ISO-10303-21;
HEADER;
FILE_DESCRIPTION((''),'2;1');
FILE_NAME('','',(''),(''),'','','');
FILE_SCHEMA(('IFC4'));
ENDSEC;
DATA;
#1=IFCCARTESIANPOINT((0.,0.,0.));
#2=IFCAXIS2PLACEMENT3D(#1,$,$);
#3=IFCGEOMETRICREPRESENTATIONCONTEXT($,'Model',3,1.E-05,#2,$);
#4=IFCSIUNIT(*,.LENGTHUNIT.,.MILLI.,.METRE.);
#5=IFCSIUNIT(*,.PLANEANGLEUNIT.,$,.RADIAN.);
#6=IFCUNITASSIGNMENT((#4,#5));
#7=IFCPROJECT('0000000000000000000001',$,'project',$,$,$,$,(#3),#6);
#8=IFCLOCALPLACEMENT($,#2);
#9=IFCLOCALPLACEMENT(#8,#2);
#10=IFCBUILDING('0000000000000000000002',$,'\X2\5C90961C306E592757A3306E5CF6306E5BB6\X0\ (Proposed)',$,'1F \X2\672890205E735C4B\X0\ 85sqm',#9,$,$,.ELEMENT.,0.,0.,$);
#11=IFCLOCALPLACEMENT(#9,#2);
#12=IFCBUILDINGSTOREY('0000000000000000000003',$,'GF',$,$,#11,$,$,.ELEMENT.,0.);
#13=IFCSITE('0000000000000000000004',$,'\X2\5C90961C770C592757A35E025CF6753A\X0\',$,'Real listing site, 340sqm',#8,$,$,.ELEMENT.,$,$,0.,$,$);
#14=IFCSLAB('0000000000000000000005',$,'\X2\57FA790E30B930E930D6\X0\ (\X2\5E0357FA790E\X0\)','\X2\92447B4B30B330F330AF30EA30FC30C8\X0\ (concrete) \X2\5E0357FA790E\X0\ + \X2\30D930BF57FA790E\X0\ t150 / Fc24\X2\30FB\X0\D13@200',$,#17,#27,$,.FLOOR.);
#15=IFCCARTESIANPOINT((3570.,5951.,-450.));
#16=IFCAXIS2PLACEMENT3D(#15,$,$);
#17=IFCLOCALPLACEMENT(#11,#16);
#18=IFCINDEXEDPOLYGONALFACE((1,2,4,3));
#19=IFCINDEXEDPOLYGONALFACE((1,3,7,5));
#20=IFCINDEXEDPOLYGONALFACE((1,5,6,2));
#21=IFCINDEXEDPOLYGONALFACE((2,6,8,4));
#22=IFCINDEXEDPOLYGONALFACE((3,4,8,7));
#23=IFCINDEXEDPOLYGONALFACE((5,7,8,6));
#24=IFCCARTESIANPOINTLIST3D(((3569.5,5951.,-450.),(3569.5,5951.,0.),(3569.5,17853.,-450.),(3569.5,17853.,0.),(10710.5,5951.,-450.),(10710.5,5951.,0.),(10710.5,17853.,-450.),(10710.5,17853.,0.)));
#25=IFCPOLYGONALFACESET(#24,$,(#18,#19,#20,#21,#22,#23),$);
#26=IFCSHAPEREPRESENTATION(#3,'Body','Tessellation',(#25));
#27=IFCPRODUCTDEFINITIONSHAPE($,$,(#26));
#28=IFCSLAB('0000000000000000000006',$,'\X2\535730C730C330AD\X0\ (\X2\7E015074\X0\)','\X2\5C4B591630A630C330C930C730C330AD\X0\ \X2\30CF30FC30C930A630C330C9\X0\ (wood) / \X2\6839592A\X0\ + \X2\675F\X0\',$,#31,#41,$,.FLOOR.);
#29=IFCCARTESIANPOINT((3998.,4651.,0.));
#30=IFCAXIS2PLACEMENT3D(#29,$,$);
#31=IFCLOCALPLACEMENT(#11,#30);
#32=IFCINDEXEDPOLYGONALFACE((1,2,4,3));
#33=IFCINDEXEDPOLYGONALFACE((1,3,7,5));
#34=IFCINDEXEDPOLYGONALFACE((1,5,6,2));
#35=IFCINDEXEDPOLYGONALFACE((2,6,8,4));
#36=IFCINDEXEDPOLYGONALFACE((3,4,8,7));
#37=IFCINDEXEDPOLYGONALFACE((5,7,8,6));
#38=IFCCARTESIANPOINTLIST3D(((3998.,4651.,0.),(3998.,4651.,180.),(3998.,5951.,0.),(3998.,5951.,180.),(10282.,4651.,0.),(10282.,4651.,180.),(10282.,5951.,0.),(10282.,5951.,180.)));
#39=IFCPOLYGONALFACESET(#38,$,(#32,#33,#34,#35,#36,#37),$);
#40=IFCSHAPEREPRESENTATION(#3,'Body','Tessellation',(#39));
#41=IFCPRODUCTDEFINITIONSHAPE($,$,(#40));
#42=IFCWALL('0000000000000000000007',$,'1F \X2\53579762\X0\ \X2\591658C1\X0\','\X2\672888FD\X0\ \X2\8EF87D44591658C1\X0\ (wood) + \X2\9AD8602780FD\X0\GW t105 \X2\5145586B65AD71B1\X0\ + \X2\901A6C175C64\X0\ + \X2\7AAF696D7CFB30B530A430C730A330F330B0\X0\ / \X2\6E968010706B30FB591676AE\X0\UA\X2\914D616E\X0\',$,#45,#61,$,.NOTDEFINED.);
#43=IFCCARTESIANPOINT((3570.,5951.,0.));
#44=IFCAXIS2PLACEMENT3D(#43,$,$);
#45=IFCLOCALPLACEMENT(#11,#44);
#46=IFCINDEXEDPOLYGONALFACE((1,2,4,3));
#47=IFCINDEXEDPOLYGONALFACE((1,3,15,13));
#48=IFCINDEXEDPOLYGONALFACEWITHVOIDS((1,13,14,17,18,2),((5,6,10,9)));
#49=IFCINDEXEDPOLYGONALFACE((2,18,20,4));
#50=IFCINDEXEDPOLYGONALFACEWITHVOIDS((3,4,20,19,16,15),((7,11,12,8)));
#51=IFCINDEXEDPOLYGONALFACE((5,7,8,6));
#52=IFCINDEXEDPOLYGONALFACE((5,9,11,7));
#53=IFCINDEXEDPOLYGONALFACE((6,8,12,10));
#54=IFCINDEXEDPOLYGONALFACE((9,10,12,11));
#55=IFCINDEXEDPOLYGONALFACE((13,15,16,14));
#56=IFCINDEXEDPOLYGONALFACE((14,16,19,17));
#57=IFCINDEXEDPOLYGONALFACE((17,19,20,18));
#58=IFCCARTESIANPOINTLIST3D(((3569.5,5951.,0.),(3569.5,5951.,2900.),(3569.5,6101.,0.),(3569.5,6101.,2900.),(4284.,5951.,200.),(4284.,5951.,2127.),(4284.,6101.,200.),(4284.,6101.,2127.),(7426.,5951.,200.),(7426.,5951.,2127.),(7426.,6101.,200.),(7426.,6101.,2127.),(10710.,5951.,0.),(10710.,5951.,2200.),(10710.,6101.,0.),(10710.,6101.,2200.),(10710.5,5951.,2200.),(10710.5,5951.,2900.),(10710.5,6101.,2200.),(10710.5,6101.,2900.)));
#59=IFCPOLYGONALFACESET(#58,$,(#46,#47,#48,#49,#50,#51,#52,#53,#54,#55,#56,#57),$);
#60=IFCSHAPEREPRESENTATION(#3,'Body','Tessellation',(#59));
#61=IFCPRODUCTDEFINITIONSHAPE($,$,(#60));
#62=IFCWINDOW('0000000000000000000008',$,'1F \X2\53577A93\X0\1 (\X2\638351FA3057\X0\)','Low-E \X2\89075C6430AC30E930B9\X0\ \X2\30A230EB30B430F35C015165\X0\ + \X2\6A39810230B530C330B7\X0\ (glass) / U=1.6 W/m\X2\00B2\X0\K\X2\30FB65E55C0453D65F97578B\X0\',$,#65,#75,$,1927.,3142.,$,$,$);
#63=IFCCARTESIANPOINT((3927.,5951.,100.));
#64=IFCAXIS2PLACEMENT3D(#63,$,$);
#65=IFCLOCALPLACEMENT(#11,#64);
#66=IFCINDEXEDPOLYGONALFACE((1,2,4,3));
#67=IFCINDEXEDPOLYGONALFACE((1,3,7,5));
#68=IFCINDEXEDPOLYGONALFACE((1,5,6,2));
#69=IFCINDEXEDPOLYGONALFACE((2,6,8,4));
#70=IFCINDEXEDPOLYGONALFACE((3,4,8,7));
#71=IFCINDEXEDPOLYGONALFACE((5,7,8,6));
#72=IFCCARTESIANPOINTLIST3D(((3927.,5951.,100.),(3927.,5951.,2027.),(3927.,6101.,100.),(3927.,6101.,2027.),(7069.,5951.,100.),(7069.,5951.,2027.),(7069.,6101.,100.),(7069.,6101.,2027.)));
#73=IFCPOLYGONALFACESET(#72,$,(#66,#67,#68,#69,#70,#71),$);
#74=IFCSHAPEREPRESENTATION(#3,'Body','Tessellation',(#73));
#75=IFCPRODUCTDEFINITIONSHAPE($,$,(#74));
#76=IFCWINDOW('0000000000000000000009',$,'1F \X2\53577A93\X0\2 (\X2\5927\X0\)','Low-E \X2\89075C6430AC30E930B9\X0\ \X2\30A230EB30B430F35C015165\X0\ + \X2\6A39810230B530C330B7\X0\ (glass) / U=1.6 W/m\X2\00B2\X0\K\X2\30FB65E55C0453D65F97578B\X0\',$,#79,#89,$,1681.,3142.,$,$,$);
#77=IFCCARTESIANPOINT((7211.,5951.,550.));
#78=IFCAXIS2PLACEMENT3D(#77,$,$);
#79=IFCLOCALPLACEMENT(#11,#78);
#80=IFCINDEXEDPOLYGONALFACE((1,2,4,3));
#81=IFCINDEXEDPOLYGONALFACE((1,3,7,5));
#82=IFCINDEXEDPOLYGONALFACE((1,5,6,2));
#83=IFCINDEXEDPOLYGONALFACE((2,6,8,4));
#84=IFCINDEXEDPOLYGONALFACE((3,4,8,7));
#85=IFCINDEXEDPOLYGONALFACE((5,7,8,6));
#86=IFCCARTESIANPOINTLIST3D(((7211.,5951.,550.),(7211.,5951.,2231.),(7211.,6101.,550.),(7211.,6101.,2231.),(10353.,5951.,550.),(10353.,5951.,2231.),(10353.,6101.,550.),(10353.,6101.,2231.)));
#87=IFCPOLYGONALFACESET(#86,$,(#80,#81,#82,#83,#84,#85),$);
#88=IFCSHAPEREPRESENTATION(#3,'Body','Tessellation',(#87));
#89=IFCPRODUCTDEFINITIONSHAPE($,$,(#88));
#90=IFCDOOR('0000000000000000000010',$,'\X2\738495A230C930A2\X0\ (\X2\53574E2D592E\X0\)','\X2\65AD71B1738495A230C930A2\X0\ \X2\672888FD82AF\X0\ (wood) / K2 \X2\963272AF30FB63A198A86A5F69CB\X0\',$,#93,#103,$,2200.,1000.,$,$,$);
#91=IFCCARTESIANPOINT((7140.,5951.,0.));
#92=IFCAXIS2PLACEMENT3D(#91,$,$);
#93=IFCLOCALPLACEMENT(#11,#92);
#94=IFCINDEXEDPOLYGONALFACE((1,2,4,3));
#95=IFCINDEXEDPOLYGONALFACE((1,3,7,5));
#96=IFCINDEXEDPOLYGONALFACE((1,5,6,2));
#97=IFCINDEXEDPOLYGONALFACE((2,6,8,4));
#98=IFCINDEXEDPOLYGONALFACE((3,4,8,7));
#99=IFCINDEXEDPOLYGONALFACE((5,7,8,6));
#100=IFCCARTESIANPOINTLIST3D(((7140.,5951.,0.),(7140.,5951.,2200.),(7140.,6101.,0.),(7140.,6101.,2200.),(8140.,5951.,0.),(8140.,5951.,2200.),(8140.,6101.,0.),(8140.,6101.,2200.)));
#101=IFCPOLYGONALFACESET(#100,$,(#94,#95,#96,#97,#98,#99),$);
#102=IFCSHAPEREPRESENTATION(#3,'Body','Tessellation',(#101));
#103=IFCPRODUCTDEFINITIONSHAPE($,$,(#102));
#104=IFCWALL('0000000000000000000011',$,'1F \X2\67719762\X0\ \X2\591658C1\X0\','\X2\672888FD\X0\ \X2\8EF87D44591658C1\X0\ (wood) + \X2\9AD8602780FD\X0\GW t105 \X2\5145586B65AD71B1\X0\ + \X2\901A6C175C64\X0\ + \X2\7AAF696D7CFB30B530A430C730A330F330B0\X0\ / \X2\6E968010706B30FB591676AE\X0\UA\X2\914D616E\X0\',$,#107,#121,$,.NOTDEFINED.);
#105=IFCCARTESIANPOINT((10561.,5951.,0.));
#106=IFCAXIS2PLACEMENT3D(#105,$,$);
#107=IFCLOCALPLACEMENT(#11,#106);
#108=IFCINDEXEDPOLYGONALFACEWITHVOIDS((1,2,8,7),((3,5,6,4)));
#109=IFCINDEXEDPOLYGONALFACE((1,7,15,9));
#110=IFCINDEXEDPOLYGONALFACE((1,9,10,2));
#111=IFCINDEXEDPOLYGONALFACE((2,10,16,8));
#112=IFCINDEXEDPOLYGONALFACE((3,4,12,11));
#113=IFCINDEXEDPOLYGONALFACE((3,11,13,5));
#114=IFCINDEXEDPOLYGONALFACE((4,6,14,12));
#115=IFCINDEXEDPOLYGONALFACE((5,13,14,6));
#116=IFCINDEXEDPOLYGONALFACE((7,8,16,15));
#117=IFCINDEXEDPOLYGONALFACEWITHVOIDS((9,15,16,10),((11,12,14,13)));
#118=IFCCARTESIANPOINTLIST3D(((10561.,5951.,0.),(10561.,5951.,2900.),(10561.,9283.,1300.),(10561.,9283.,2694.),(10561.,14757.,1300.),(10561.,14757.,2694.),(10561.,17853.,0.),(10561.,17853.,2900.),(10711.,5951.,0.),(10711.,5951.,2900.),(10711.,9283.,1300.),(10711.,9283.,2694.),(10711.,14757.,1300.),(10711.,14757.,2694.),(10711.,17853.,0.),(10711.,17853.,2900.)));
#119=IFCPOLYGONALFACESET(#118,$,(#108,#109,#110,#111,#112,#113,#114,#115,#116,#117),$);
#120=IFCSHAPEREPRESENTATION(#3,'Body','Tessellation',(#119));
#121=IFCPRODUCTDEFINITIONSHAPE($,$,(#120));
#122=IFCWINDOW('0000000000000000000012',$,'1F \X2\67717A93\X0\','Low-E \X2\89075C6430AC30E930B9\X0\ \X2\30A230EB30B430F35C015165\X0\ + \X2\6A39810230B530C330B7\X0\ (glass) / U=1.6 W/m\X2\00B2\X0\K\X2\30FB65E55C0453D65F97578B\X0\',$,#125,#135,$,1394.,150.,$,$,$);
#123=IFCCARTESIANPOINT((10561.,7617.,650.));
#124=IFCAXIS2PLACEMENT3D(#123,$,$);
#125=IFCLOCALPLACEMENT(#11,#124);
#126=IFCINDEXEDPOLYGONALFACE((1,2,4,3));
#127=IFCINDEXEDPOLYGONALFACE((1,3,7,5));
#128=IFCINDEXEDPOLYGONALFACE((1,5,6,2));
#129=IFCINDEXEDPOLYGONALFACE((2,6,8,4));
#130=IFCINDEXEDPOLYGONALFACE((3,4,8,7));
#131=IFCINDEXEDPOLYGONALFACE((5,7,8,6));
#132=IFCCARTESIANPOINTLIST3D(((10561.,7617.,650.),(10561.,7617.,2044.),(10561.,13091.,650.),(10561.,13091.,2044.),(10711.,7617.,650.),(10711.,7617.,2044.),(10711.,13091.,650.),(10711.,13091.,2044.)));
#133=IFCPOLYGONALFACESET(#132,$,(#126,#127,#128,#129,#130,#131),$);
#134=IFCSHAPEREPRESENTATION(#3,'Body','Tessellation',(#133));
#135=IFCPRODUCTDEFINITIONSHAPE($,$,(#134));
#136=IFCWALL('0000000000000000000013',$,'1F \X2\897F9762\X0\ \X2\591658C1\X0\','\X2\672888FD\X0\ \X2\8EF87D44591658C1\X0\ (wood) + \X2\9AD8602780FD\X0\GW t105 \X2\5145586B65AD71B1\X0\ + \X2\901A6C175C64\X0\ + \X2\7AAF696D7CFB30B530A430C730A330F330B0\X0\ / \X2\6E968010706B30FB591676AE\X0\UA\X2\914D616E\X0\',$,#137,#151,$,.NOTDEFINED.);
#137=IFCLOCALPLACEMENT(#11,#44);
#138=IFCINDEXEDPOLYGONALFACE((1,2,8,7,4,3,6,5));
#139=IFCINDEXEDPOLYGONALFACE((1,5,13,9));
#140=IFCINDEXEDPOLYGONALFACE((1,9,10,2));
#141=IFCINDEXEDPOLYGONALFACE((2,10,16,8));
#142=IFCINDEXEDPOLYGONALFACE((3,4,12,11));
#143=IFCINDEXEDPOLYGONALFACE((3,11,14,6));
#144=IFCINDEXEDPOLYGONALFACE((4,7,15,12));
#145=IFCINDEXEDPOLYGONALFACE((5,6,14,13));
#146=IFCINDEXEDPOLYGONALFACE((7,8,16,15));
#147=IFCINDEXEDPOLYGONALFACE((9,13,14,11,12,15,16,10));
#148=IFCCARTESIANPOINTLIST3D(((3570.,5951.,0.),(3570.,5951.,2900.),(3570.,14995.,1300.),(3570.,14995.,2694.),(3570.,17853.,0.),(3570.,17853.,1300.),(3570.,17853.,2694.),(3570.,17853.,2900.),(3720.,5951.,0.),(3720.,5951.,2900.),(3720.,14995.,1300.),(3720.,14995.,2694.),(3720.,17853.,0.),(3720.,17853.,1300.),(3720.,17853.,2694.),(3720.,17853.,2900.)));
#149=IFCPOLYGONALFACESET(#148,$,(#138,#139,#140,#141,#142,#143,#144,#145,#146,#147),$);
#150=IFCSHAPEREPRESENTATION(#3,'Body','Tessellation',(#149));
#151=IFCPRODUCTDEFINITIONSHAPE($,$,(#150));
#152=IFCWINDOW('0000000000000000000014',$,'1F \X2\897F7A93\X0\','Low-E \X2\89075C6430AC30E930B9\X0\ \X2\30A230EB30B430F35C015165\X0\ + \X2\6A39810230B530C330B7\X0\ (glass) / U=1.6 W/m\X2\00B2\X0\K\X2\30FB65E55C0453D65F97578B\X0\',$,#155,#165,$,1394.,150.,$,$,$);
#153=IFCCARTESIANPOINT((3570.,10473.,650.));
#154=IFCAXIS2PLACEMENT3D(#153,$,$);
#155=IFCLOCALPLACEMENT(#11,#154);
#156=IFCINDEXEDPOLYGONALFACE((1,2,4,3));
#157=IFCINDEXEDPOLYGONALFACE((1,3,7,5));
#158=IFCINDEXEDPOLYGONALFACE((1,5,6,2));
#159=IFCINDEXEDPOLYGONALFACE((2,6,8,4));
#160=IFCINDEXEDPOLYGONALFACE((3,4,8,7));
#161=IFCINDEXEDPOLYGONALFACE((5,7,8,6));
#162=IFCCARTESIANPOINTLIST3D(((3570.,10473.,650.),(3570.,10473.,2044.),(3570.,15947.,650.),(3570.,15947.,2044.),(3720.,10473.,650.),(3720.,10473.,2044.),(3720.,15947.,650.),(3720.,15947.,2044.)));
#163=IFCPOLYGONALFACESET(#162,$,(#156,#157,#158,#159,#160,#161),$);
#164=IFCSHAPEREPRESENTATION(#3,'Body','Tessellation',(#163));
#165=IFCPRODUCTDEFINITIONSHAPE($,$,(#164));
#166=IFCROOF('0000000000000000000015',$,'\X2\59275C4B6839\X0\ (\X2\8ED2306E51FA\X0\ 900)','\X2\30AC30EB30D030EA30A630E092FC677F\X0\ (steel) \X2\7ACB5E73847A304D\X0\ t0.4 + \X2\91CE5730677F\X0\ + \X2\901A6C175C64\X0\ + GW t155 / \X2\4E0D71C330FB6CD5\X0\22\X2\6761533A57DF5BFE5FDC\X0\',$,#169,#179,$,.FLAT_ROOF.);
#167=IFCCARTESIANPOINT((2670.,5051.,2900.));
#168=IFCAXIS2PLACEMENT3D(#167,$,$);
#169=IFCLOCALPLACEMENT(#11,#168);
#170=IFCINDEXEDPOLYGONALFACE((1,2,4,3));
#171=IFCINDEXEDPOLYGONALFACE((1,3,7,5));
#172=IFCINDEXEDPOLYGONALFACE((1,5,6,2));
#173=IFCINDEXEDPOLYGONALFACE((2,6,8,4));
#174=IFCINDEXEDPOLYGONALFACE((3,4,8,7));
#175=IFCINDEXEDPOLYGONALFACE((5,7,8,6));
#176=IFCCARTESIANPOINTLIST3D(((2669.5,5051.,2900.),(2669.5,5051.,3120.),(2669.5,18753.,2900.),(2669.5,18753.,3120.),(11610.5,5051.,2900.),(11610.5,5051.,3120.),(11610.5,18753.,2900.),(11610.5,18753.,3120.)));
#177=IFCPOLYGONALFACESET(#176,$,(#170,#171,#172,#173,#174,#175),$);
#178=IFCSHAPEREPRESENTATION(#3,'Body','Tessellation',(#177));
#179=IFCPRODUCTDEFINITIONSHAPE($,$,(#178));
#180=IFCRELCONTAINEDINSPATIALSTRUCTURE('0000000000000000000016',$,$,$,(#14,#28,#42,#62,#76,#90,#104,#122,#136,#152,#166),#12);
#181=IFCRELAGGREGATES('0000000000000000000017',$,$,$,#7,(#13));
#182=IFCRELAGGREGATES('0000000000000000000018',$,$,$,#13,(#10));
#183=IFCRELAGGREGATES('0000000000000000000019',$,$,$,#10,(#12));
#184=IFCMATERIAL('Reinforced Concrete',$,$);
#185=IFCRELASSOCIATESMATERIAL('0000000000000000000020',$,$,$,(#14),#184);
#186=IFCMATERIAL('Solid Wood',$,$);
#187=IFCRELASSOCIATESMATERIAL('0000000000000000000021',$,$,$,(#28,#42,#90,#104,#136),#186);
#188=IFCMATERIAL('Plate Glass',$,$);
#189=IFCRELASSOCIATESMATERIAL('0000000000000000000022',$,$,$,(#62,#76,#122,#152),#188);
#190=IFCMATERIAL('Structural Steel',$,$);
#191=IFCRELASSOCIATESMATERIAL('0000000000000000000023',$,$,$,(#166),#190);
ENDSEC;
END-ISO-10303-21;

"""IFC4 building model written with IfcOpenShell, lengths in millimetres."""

from ifc_helpers import new_model, si_unit, frame, frame_2d, origin, place, context, project, spatial, rectangle, extrude, material, element, fill, save


model = new_model("IFC4")

# Units and contexts
model_context = context("Model", 3, precision=1e-05, world=origin())
ifc_project = project(units=[si_unit("LENGTHUNIT", "METRE", prefix="MILLI"), si_unit("PLANEANGLEUNIT", "RADIAN")], contexts=[model_context])

# Site, building, storey
site_placement = place(None, origin())
site = spatial("IfcSite", under=ifc_project, at=site_placement, Name="岐阜県大垣市島町", ObjectType="Real listing site, 340sqm", CompositionType="ELEMENT", RefElevation=0.0)
building_placement = place(site_placement, origin())
building = spatial("IfcBuilding", under=site, at=building_placement, Name="岐阜の大垣の島の家 (Proposed)", ObjectType="1F 木造平屋 85sqm", CompositionType="ELEMENT", ElevationOfRefHeight=0.0, ElevationOfTerrain=0.0)
storey_placement = place(building_placement, origin())
storey = spatial("IfcBuildingStorey", under=building, at=storey_placement, Name="GF", CompositionType="ELEMENT", Elevation=0.0)

# Slabs
ifc_material_1 = material(Name="Reinforced Concrete")
slab_1_placement = place(storey_placement, frame((3570.0, 5951.0, -450.0)))
element("IfcSlab", 1, at=slab_1_placement, inside=storey, material=ifc_material_1, Name="基礎スラブ (布基礎)", Description="鉄筋コンクリート (concrete) 布基礎 + ベタ基礎 t150 / Fc24・D13@200", PredefinedType="FLOOR", context=model_context, shape_type="SweptSolid", body=[
    extrude(rectangle(XDim=7141.0, YDim=11902.0, at=frame_2d((3570.0, 5951.0))), frame((3570.0, 5951.0, -450.0)), (0.0, 0.0, 1.0), 450.0),
])
ifc_material_2 = material(Name="Solid Wood")
slab_2_placement = place(storey_placement, frame((3998.0, 4651.0, 0.0)))
element("IfcSlab", 2, at=slab_2_placement, inside=storey, material=ifc_material_2, Name="南デッキ (縁側)", Description="屋外ウッドデッキ ハードウッド (wood) / 根太 + 束", PredefinedType="FLOOR", context=model_context, shape_type="SweptSolid", body=[
    extrude(rectangle(XDim=6284.0, YDim=1300.0, at=frame_2d((3142.0, 650.0))), frame((3998.0, 4651.0, 0.0)), (0.0, 0.0, 1.0), 180.0),
])

# Wall, openings, windows, door
wall_1_placement = place(storey_placement, frame((3570.0, 5951.0, 0.0)))
wall_1 = element("IfcWall", 3, at=wall_1_placement, inside=storey, material=ifc_material_2, Name="1F 南面 外壁", Description="木製 軸組外壁 (wood) + 高性能GW t105 充填断熱 + 通気層 + 窯業系サイディング / 準耐火・外皮UA配慮", PredefinedType="NOTDEFINED", context=model_context, shape_type="SweptSolid", body=[
    extrude(rectangle(XDim=7141.0, YDim=150.0, at=frame_2d((3570.0, 75.0))), frame((3570.0, 5951.0, 0.0)), (0.0, 0.0, 1.0), 2900.0),
])
opening_1_placement = place(storey_placement, frame((3927.0, 5951.0, 100.0)))
opening_1 = element("IfcOpeningElement", 4, at=opening_1_placement, cuts=wall_1, PredefinedType="NOTDEFINED", context=model_context, shape_type="SweptSolid", body=[
    extrude(rectangle(XDim=3142.0, YDim=150.0, at=frame_2d((1571.0, 75.0))), frame((3927.0, 5951.0, 100.0)), (0.0, 0.0, 1.0), 1927.0),
])
opening_2_placement = place(storey_placement, frame((7211.0, 5951.0, 550.0)))
opening_2 = element("IfcOpeningElement", 5, at=opening_2_placement, cuts=wall_1, PredefinedType="NOTDEFINED", context=model_context, shape_type="SweptSolid", body=[
    extrude(rectangle(XDim=3142.0, YDim=150.0, at=frame_2d((1571.0, 75.0))), frame((7211.0, 5951.0, 550.0)), (0.0, 0.0, 1.0), 1681.0),
])
opening_3_placement = place(storey_placement, frame((7140.0, 5951.0, 0.0)))
opening_3 = element("IfcOpeningElement", 6, at=opening_3_placement, cuts=wall_1, PredefinedType="NOTDEFINED", context=model_context, shape_type="SweptSolid", body=[
    extrude(rectangle(XDim=1000.0, YDim=150.0, at=frame_2d((500.0, 75.0))), frame((7140.0, 5951.0, 0.0)), (0.0, 0.0, 1.0), 2200.0),
])
ifc_material_3 = material(Name="Plate Glass")
window_1_placement = place(storey_placement, frame((3927.0, 5951.0, 100.0)))
window_1 = element("IfcWindow", 7, at=window_1_placement, inside=storey, material=ifc_material_3, Name="1F 南窓1 (掃出し)", Description="Low-E 複層ガラス アルゴン封入 + 樹脂サッシ (glass) / U=1.6 W/m²K・日射取得型", OverallHeight=1927.0, OverallWidth=3142.0, context=model_context, shape_type="SweptSolid", body=[
    extrude(rectangle(XDim=3142.0, YDim=150.0, at=frame_2d((1571.0, 75.0))), frame((3927.0, 5951.0, 100.0)), (0.0, 0.0, 1.0), 1927.0),
])
fill(opening_1, window_1)
window_2_placement = place(storey_placement, frame((7211.0, 5951.0, 550.0)))
window_2 = element("IfcWindow", 8, at=window_2_placement, inside=storey, material=ifc_material_3, Name="1F 南窓2 (大)", Description="Low-E 複層ガラス アルゴン封入 + 樹脂サッシ (glass) / U=1.6 W/m²K・日射取得型", OverallHeight=1681.0, OverallWidth=3142.0, context=model_context, shape_type="SweptSolid", body=[
    extrude(rectangle(XDim=3142.0, YDim=150.0, at=frame_2d((1571.0, 75.0))), frame((7211.0, 5951.0, 550.0)), (0.0, 0.0, 1.0), 1681.0),
])
fill(opening_2, window_2)
door_placement = place(storey_placement, frame((7140.0, 5951.0, 0.0)))
door = element("IfcDoor", 9, at=door_placement, inside=storey, material=ifc_material_2, Name="玄関ドア (南中央)", Description="断熱玄関ドア 木製芯 (wood) / K2 防犯・採風機構", OverallHeight=2200.0, OverallWidth=1000.0, context=model_context, shape_type="SweptSolid", body=[
    extrude(rectangle(XDim=1000.0, YDim=150.0, at=frame_2d((500.0, 75.0))), frame((7140.0, 5951.0, 0.0)), (0.0, 0.0, 1.0), 2200.0),
])
fill(opening_3, door)

# Walls, openings, windows
wall_2_placement = place(storey_placement, frame((10561.0, 5951.0, 0.0)))
wall_2 = element("IfcWall", 10, at=wall_2_placement, inside=storey, material=ifc_material_2, Name="1F 東面 外壁", Description="木製 軸組外壁 (wood) + 高性能GW t105 充填断熱 + 通気層 + 窯業系サイディング / 準耐火・外皮UA配慮", PredefinedType="NOTDEFINED", context=model_context, shape_type="SweptSolid", body=[
    extrude(rectangle(XDim=150.0, YDim=11902.0, at=frame_2d((75.0, 5951.0))), frame((10561.0, 5951.0, 0.0)), (0.0, 0.0, 1.0), 2900.0),
])
opening_4_placement = place(storey_placement, frame((10561.0, 7617.0, 650.0)))
opening_4 = element("IfcOpeningElement", 11, at=opening_4_placement, cuts=wall_2, PredefinedType="NOTDEFINED", context=model_context, shape_type="SweptSolid", body=[
    extrude(rectangle(XDim=150.0, YDim=5474.0, at=frame_2d((75.0, 2737.0))), frame((10561.0, 7617.0, 650.0)), (0.0, 0.0, 1.0), 1394.0),
])
window_3_placement = place(storey_placement, frame((10561.0, 7617.0, 650.0)))
window_3 = element("IfcWindow", 12, at=window_3_placement, inside=storey, material=ifc_material_3, Name="1F 東窓", Description="Low-E 複層ガラス アルゴン封入 + 樹脂サッシ (glass) / U=1.6 W/m²K・日射取得型", OverallHeight=1394.0, OverallWidth=150.0, context=model_context, shape_type="SweptSolid", body=[
    extrude(rectangle(XDim=150.0, YDim=5474.0, at=frame_2d((75.0, 2737.0))), frame((10561.0, 7617.0, 650.0)), (0.0, 0.0, 1.0), 1394.0),
])
fill(opening_4, window_3)
wall_3_placement = place(storey_placement, frame((3570.0, 5951.0, 0.0)))
wall_3 = element("IfcWall", 13, at=wall_3_placement, inside=storey, material=ifc_material_2, Name="1F 西面 外壁", Description="木製 軸組外壁 (wood) + 高性能GW t105 充填断熱 + 通気層 + 窯業系サイディング / 準耐火・外皮UA配慮", PredefinedType="NOTDEFINED", context=model_context, shape_type="SweptSolid", body=[
    extrude(rectangle(XDim=150.0, YDim=11902.0, at=frame_2d((75.0, 5951.0))), frame((3570.0, 5951.0, 0.0)), (0.0, 0.0, 1.0), 2900.0),
])
opening_5_placement = place(storey_placement, frame((3570.0, 10473.0, 650.0)))
opening_5 = element("IfcOpeningElement", 14, at=opening_5_placement, cuts=wall_3, PredefinedType="NOTDEFINED", context=model_context, shape_type="SweptSolid", body=[
    extrude(rectangle(XDim=150.0, YDim=5474.0, at=frame_2d((75.0, 2737.0))), frame((3570.0, 10473.0, 650.0)), (0.0, 0.0, 1.0), 1394.0),
])
window_4_placement = place(storey_placement, frame((3570.0, 10473.0, 650.0)))
window_4 = element("IfcWindow", 15, at=window_4_placement, inside=storey, material=ifc_material_3, Name="1F 西窓", Description="Low-E 複層ガラス アルゴン封入 + 樹脂サッシ (glass) / U=1.6 W/m²K・日射取得型", OverallHeight=1394.0, OverallWidth=150.0, context=model_context, shape_type="SweptSolid", body=[
    extrude(rectangle(XDim=150.0, YDim=5474.0, at=frame_2d((75.0, 2737.0))), frame((3570.0, 10473.0, 650.0)), (0.0, 0.0, 1.0), 1394.0),
])
fill(opening_5, window_4)

# Roof
ifc_material_4 = material(Name="Structural Steel")
roof_placement = place(storey_placement, frame((2670.0, 5051.0, 2900.0)))
element("IfcRoof", 16, at=roof_placement, inside=storey, material=ifc_material_4, Name="大屋根 (軒の出 900)", Description="ガルバリウム鋼板 (steel) 立平葺き t0.4 + 野地板 + 通気層 + GW t155 / 不燃・法22条区域対応", PredefinedType="FLAT_ROOF", context=model_context, shape_type="SweptSolid", body=[
    extrude(rectangle(XDim=8941.0, YDim=13702.0, at=frame_2d((4470.0, 6851.0))), frame((2670.0, 5051.0, 2900.0)), (0.0, 0.0, 1.0), 220.0),
])

save(model, "model.ifc")
